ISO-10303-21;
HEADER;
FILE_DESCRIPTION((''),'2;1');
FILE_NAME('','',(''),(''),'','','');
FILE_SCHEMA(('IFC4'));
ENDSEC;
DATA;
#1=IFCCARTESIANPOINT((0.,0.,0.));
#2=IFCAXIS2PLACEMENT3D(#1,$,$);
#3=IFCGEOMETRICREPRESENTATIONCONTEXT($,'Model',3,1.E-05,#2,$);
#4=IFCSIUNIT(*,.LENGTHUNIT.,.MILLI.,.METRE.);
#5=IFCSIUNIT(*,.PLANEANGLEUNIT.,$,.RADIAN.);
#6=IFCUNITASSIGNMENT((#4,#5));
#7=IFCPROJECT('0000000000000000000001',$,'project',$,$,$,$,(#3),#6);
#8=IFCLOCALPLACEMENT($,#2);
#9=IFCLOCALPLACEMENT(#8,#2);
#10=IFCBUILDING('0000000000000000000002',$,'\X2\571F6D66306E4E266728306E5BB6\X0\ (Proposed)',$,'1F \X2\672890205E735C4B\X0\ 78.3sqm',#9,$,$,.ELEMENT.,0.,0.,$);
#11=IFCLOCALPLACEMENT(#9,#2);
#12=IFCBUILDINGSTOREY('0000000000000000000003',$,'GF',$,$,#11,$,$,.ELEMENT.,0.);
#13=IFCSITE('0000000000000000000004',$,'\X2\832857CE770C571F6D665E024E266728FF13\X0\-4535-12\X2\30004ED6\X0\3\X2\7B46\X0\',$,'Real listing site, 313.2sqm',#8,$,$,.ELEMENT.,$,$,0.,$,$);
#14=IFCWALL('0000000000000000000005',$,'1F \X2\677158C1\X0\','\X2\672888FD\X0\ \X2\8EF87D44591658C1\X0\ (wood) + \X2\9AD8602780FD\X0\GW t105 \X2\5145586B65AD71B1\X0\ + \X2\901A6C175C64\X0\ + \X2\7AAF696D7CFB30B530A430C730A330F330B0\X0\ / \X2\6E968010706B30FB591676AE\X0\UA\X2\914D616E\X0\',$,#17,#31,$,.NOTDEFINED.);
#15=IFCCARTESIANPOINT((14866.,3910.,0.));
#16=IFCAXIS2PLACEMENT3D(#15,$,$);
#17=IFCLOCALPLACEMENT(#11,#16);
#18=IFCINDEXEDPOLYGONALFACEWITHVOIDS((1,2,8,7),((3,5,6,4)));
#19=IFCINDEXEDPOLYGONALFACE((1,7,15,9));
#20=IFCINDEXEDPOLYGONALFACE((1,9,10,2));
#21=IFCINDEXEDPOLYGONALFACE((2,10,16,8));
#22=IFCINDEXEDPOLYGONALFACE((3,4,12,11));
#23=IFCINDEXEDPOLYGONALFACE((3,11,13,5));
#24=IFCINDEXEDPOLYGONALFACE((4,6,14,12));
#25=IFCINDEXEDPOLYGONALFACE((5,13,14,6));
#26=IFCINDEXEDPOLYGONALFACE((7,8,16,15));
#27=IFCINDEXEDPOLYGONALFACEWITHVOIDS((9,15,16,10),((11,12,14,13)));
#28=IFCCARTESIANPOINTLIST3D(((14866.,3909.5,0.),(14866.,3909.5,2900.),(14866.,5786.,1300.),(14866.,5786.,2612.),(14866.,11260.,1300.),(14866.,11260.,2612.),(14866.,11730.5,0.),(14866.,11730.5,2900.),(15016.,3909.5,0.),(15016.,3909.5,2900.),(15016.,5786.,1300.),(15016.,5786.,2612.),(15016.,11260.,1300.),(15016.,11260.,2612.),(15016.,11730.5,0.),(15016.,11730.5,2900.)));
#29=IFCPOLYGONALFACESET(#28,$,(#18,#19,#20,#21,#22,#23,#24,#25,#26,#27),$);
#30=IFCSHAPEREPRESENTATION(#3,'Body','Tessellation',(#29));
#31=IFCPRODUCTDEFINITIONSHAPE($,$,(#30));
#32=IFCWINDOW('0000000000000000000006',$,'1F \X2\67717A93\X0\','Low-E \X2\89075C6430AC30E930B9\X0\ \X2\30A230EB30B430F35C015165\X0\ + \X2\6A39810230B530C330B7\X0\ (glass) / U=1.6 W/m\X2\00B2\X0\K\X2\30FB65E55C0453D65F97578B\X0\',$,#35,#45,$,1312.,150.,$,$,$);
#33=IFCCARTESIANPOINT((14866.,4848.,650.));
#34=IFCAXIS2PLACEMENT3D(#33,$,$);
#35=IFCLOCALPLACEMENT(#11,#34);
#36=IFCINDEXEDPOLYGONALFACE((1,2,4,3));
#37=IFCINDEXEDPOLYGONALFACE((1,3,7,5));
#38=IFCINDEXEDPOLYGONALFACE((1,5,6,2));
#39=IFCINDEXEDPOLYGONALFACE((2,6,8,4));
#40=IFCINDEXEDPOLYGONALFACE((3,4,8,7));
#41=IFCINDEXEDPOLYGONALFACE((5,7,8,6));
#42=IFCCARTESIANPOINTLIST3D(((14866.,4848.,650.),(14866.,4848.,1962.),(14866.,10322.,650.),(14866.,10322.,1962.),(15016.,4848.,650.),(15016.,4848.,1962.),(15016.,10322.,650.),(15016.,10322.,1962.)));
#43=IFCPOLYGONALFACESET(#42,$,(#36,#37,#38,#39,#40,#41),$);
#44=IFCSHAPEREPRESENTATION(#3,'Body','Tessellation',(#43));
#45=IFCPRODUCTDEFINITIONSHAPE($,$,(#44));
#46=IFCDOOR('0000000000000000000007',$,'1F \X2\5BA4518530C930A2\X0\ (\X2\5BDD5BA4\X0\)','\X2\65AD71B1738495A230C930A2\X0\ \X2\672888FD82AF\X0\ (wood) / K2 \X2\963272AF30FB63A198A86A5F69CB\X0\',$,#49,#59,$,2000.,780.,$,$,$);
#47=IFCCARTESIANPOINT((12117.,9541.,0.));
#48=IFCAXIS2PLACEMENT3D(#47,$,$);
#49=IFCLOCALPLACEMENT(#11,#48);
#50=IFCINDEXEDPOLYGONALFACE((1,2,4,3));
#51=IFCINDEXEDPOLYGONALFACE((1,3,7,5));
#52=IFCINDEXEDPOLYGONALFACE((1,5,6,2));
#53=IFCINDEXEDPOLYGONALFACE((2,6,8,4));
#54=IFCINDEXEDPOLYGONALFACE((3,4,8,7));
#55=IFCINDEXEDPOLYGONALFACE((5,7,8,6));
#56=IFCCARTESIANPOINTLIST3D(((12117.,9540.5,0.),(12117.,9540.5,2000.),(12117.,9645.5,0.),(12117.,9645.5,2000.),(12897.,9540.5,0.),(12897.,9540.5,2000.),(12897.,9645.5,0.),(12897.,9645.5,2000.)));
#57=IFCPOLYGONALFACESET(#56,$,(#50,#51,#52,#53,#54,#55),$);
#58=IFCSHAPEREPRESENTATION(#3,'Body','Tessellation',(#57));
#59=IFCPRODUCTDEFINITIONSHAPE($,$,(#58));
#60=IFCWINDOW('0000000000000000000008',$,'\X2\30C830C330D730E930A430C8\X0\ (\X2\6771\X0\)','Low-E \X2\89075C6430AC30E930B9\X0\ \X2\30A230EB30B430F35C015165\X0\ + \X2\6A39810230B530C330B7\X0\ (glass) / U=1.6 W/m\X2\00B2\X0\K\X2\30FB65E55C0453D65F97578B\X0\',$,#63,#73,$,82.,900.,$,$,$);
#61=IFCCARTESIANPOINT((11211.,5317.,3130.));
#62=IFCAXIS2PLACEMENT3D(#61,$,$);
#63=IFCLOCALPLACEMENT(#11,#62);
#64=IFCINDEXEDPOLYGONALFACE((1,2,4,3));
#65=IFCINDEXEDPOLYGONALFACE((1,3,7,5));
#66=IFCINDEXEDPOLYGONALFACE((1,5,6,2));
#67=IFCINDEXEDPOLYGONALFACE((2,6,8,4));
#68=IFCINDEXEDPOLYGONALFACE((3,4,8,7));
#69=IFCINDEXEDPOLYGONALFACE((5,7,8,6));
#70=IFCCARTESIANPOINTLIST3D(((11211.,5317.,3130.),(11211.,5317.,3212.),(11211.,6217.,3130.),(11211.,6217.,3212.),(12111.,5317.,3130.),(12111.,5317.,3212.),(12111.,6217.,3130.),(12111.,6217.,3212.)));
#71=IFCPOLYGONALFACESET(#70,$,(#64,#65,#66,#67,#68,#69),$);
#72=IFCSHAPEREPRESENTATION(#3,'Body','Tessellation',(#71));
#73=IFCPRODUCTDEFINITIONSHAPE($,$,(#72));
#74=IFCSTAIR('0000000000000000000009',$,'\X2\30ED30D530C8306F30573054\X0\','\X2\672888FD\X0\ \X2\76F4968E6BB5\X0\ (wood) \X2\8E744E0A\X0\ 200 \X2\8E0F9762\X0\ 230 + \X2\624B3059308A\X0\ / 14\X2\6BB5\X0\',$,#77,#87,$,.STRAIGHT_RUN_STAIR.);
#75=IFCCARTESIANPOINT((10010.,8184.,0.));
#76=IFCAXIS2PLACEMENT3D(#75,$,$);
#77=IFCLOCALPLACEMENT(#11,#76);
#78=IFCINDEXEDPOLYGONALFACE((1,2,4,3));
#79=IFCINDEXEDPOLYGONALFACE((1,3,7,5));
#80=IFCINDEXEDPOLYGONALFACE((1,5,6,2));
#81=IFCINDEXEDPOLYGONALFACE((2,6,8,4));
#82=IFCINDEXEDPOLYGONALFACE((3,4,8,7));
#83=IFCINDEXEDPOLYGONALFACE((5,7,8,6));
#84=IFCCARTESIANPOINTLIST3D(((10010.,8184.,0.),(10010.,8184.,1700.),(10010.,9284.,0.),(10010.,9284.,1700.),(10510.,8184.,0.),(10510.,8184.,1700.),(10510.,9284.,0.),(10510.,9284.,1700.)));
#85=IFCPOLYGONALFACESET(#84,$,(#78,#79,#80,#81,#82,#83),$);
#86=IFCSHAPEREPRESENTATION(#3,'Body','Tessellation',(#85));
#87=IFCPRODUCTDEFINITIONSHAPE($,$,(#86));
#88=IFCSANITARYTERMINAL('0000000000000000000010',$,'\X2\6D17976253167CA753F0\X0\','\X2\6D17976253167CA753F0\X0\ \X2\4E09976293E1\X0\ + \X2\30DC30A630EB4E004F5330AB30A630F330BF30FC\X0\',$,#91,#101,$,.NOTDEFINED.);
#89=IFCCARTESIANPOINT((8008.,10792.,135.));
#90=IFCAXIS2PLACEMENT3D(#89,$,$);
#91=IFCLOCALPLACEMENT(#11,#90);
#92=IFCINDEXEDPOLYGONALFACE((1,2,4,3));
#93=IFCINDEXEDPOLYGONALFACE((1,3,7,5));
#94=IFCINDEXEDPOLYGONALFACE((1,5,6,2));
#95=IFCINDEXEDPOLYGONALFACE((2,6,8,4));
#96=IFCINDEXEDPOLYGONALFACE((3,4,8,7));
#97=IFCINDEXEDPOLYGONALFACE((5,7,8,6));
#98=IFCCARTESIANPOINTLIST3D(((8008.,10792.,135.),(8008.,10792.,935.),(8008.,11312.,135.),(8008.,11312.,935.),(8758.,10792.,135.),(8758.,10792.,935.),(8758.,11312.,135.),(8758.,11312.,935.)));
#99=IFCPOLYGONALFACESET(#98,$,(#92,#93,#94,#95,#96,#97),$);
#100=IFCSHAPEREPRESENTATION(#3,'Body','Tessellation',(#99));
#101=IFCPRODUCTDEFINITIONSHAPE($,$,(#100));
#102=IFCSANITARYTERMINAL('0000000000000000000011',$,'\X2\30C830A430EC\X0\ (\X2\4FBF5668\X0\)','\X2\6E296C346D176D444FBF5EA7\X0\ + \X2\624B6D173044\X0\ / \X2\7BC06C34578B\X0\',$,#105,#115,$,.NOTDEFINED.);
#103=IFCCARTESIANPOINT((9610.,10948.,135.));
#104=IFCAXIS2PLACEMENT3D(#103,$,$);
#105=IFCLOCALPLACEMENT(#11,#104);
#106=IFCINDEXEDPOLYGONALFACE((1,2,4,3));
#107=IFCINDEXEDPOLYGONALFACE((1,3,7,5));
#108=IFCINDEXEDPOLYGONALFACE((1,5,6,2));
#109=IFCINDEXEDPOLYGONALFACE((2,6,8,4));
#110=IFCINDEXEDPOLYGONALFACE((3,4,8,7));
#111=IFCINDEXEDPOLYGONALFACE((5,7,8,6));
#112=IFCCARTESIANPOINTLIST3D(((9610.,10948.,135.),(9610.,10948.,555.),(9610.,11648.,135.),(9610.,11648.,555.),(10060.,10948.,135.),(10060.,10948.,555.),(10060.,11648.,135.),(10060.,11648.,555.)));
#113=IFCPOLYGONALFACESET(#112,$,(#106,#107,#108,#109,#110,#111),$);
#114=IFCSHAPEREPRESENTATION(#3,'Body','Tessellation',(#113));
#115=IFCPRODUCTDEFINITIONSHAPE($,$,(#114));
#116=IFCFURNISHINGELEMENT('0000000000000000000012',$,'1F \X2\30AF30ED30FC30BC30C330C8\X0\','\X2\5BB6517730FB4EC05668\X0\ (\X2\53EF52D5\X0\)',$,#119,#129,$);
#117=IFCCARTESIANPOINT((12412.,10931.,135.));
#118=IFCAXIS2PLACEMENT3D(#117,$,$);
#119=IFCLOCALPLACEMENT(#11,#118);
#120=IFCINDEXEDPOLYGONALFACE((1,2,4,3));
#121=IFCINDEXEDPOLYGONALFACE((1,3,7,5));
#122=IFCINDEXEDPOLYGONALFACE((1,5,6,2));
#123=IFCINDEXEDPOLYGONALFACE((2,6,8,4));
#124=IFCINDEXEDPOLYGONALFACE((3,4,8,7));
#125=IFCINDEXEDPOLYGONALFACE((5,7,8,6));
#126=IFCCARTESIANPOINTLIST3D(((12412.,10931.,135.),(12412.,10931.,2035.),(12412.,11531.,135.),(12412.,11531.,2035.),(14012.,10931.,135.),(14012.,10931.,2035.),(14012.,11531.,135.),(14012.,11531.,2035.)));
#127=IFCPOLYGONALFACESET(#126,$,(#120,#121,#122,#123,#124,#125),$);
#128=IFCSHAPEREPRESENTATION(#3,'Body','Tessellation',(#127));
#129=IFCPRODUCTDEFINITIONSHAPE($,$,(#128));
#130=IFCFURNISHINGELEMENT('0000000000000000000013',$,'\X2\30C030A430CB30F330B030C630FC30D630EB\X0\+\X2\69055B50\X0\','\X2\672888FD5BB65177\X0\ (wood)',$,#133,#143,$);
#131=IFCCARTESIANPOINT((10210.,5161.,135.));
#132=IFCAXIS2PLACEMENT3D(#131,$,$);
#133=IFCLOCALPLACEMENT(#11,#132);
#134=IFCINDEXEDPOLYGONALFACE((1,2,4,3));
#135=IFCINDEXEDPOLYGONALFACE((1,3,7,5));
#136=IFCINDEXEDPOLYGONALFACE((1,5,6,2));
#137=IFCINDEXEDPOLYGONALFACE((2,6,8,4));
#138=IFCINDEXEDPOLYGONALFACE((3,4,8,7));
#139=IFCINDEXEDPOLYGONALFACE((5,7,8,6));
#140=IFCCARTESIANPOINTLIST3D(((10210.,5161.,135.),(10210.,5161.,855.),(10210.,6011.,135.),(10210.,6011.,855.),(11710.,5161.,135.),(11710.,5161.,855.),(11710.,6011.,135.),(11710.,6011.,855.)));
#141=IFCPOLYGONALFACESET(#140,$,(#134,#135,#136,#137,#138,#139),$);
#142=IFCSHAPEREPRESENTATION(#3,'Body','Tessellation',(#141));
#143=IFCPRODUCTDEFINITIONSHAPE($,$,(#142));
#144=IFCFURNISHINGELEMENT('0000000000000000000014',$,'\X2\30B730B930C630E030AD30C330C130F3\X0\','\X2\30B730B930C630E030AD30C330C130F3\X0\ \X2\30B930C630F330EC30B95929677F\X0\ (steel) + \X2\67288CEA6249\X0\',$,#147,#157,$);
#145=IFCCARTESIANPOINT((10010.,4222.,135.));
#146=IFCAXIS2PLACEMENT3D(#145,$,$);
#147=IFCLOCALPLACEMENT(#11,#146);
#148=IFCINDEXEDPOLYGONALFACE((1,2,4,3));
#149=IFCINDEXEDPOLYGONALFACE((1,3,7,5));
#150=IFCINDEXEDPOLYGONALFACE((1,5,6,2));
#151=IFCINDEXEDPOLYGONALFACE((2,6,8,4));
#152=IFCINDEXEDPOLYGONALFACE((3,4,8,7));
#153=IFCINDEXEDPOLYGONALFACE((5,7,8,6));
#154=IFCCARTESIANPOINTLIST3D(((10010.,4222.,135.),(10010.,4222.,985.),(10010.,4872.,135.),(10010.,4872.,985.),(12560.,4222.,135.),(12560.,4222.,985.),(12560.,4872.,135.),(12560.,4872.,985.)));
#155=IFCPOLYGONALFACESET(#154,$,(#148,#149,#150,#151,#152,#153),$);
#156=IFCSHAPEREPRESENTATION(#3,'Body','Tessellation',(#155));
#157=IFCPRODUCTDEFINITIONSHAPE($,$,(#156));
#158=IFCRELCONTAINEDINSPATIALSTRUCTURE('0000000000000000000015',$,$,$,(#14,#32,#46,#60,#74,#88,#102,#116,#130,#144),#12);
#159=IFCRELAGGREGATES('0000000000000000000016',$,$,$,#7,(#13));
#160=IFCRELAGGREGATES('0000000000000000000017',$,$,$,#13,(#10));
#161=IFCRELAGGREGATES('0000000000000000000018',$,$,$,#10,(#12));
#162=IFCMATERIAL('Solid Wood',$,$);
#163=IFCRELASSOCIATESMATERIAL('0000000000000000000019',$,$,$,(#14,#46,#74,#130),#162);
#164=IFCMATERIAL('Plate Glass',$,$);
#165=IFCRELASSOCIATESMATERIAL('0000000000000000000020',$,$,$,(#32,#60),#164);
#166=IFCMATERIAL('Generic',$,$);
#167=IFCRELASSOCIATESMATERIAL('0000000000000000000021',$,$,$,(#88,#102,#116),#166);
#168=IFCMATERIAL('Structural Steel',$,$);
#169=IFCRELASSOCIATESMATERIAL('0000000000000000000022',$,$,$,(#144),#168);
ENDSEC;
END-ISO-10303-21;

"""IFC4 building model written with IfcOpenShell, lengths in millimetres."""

from ifc_helpers import new_model, si_unit, frame, frame_2d, origin, place, context, project, spatial, rectangle, extrude, material, element, fill, save


model = new_model("IFC4")

# Units and contexts
model_context = context("Model", 3, precision=1e-05, world=origin())
ifc_project = project(units=[si_unit("LENGTHUNIT", "METRE", prefix="MILLI"), si_unit("PLANEANGLEUNIT", "RADIAN")], contexts=[model_context])

# Site, building, storey
site_placement = place(None, origin())
site = spatial("IfcSite", under=ifc_project, at=site_placement, Name="茨城県土浦市並木３-4535-12　他3筆", ObjectType="Real listing site, 313.2sqm", CompositionType="ELEMENT", RefElevation=0.0)
building_placement = place(site_placement, origin())
building = spatial("IfcBuilding", under=site, at=building_placement, Name="土浦の並木の家 (Proposed)", ObjectType="1F 木造平屋 78.3sqm", CompositionType="ELEMENT", ElevationOfRefHeight=0.0, ElevationOfTerrain=0.0)
storey_placement = place(building_placement, origin())
storey = spatial("IfcBuildingStorey", under=building, at=storey_placement, Name="GF", CompositionType="ELEMENT", Elevation=0.0)

# Shared definitions
ifc_material_1 = material(Name="Solid Wood")

# Wall, opening, window
wall_1_placement = place(storey_placement, frame((14866.0, 3910.0, 0.0)))
wall_1 = element("IfcWall", 1, at=wall_1_placement, inside=storey, material=ifc_material_1, Name="1F 東壁", Description="木製 軸組外壁 (wood) + 高性能GW t105 充填断熱 + 通気層 + 窯業系サイディング / 準耐火・外皮UA配慮", PredefinedType="NOTDEFINED", context=model_context, shape_type="SweptSolid", body=[
    extrude(rectangle(XDim=150.0, YDim=7821.0, at=frame_2d((75.0, 3910.0))), frame((14866.0, 3910.0, 0.0)), (0.0, 0.0, 1.0), 2900.0),
])
opening_1_placement = place(storey_placement, frame((14866.0, 4848.0, 650.0)))
opening_1 = element("IfcOpeningElement", 2, at=opening_1_placement, cuts=wall_1, PredefinedType="NOTDEFINED", context=model_context, shape_type="SweptSolid", body=[
    extrude(rectangle(XDim=150.0, YDim=5474.0, at=frame_2d((75.0, 2737.0))), frame((14866.0, 4848.0, 650.0)), (0.0, 0.0, 1.0), 1312.0),
])
ifc_material_2 = material(Name="Plate Glass")
window_1_placement = place(storey_placement, frame((14866.0, 4848.0, 650.0)))
window_1 = element("IfcWindow", 3, at=window_1_placement, inside=storey, material=ifc_material_2, Name="1F 東窓", Description="Low-E 複層ガラス アルゴン封入 + 樹脂サッシ (glass) / U=1.6 W/m²K・日射取得型", OverallHeight=1312.0, OverallWidth=150.0, context=model_context, shape_type="SweptSolid", body=[
    extrude(rectangle(XDim=150.0, YDim=5474.0, at=frame_2d((75.0, 2737.0))), frame((14866.0, 4848.0, 650.0)), (0.0, 0.0, 1.0), 1312.0),
])
fill(opening_1, window_1)

# Door
door_placement = place(storey_placement, frame((12117.0, 9541.0, 0.0)))
element("IfcDoor", 4, at=door_placement, inside=storey, material=ifc_material_1, Name="1F 室内ドア (寝室)", Description="断熱玄関ドア 木製芯 (wood) / K2 防犯・採風機構", OverallHeight=2000.0, OverallWidth=780.0, context=model_context, shape_type="SweptSolid", body=[
    extrude(rectangle(XDim=780.0, YDim=105.0, at=frame_2d((390.0, 52.0))), frame((12117.0, 9541.0, 0.0)), (0.0, 0.0, 1.0), 2000.0),
])

# Window
window_2_placement = place(storey_placement, frame((11211.0, 5317.0, 3130.0)))
element("IfcWindow", 5, at=window_2_placement, inside=storey, material=ifc_material_2, Name="トップライト (東)", Description="Low-E 複層ガラス アルゴン封入 + 樹脂サッシ (glass) / U=1.6 W/m²K・日射取得型", OverallHeight=82.0, OverallWidth=900.0, context=model_context, shape_type="SweptSolid", body=[
    extrude(rectangle(XDim=900.0, YDim=900.0, at=frame_2d((450.0, 450.0))), frame((11211.0, 5317.0, 3130.0)), (0.0, 0.0, 1.0), 82.0),
])

# Stair
stair_placement = place(storey_placement, frame((10010.0, 8184.0, 0.0)))
element("IfcStair", 6, at=stair_placement, inside=storey, material=ifc_material_1, Name="ロフトはしご", Description="木製 直階段 (wood) 蹴上 200 踏面 230 + 手すり / 14段", PredefinedType="STRAIGHT_RUN_STAIR", context=model_context, shape_type="SweptSolid", body=[
    extrude(rectangle(XDim=500.0, YDim=1100.0, at=frame_2d((250.0, 550.0))), frame((10010.0, 8184.0, 0.0)), (0.0, 0.0, 1.0), 1700.0),
])

# Shared definitions
ifc_material_3 = material(Name="Structural Steel")

# Shared definitions
ifc_material_4 = material(Name="Generic")

# Sanitary terminals
sanitary_terminal_1_placement = place(storey_placement, frame((8008.0, 10792.0, 135.0)))
element("IfcSanitaryTerminal", 7, at=sanitary_terminal_1_placement, inside=storey, material=ifc_material_4, Name="洗面化粧台", Description="洗面化粧台 三面鏡 + ボウル一体カウンター", PredefinedType="NOTDEFINED", context=model_context, shape_type="SweptSolid", body=[
    extrude(rectangle(XDim=750.0, YDim=520.0, at=frame_2d((375.0, 260.0))), frame((8008.0, 10792.0, 135.0)), (0.0, 0.0, 1.0), 800.0),
])
sanitary_terminal_2_placement = place(storey_placement, frame((9610.0, 10948.0, 135.0)))
element("IfcSanitaryTerminal", 8, at=sanitary_terminal_2_placement, inside=storey, material=ifc_material_4, Name="トイレ (便器)", Description="温水洗浄便座 + 手洗い / 節水型", PredefinedType="NOTDEFINED", context=model_context, shape_type="SweptSolid", body=[
    extrude(rectangle(XDim=450.0, YDim=700.0, at=frame_2d((225.0, 350.0))), frame((9610.0, 10948.0, 135.0)), (0.0, 0.0, 1.0), 420.0),
])

# Furnishing elements
furnishing_1_placement = place(storey_placement, frame((12412.0, 10931.0, 135.0)))
element("IfcFurnishingElement", 9, at=furnishing_1_placement, inside=storey, material=ifc_material_4, Name="1F クローゼット", Description="家具・什器 (可動)", context=model_context, shape_type="SweptSolid", body=[
    extrude(rectangle(XDim=1600.0, YDim=600.0, at=frame_2d((800.0, 300.0))), frame((12412.0, 10931.0, 135.0)), (0.0, 0.0, 1.0), 1900.0),
])
furnishing_2_placement = place(storey_placement, frame((10210.0, 5161.0, 135.0)))
element("IfcFurnishingElement", 10, at=furnishing_2_placement, inside=storey, material=ifc_material_1, Name="ダイニングテーブル+椅子", Description="木製家具 (wood)", context=model_context, shape_type="SweptSolid", body=[
    extrude(rectangle(XDim=1500.0, YDim=850.0, at=frame_2d((750.0, 425.0))), frame((10210.0, 5161.0, 135.0)), (0.0, 0.0, 1.0), 720.0),
])
furnishing_3_placement = place(storey_placement, frame((10010.0, 4222.0, 135.0)))
element("IfcFurnishingElement", 11, at=furnishing_3_placement, inside=storey, material=ifc_material_3, Name="システムキッチン", Description="システムキッチン ステンレス天板 (steel) + 木質扉", context=model_context, shape_type="SweptSolid", body=[
    extrude(rectangle(XDim=2550.0, YDim=650.0, at=frame_2d((1275.0, 325.0))), frame((10010.0, 4222.0, 135.0)), (0.0, 0.0, 1.0), 850.0),
])

save(model, "model.ifc")
